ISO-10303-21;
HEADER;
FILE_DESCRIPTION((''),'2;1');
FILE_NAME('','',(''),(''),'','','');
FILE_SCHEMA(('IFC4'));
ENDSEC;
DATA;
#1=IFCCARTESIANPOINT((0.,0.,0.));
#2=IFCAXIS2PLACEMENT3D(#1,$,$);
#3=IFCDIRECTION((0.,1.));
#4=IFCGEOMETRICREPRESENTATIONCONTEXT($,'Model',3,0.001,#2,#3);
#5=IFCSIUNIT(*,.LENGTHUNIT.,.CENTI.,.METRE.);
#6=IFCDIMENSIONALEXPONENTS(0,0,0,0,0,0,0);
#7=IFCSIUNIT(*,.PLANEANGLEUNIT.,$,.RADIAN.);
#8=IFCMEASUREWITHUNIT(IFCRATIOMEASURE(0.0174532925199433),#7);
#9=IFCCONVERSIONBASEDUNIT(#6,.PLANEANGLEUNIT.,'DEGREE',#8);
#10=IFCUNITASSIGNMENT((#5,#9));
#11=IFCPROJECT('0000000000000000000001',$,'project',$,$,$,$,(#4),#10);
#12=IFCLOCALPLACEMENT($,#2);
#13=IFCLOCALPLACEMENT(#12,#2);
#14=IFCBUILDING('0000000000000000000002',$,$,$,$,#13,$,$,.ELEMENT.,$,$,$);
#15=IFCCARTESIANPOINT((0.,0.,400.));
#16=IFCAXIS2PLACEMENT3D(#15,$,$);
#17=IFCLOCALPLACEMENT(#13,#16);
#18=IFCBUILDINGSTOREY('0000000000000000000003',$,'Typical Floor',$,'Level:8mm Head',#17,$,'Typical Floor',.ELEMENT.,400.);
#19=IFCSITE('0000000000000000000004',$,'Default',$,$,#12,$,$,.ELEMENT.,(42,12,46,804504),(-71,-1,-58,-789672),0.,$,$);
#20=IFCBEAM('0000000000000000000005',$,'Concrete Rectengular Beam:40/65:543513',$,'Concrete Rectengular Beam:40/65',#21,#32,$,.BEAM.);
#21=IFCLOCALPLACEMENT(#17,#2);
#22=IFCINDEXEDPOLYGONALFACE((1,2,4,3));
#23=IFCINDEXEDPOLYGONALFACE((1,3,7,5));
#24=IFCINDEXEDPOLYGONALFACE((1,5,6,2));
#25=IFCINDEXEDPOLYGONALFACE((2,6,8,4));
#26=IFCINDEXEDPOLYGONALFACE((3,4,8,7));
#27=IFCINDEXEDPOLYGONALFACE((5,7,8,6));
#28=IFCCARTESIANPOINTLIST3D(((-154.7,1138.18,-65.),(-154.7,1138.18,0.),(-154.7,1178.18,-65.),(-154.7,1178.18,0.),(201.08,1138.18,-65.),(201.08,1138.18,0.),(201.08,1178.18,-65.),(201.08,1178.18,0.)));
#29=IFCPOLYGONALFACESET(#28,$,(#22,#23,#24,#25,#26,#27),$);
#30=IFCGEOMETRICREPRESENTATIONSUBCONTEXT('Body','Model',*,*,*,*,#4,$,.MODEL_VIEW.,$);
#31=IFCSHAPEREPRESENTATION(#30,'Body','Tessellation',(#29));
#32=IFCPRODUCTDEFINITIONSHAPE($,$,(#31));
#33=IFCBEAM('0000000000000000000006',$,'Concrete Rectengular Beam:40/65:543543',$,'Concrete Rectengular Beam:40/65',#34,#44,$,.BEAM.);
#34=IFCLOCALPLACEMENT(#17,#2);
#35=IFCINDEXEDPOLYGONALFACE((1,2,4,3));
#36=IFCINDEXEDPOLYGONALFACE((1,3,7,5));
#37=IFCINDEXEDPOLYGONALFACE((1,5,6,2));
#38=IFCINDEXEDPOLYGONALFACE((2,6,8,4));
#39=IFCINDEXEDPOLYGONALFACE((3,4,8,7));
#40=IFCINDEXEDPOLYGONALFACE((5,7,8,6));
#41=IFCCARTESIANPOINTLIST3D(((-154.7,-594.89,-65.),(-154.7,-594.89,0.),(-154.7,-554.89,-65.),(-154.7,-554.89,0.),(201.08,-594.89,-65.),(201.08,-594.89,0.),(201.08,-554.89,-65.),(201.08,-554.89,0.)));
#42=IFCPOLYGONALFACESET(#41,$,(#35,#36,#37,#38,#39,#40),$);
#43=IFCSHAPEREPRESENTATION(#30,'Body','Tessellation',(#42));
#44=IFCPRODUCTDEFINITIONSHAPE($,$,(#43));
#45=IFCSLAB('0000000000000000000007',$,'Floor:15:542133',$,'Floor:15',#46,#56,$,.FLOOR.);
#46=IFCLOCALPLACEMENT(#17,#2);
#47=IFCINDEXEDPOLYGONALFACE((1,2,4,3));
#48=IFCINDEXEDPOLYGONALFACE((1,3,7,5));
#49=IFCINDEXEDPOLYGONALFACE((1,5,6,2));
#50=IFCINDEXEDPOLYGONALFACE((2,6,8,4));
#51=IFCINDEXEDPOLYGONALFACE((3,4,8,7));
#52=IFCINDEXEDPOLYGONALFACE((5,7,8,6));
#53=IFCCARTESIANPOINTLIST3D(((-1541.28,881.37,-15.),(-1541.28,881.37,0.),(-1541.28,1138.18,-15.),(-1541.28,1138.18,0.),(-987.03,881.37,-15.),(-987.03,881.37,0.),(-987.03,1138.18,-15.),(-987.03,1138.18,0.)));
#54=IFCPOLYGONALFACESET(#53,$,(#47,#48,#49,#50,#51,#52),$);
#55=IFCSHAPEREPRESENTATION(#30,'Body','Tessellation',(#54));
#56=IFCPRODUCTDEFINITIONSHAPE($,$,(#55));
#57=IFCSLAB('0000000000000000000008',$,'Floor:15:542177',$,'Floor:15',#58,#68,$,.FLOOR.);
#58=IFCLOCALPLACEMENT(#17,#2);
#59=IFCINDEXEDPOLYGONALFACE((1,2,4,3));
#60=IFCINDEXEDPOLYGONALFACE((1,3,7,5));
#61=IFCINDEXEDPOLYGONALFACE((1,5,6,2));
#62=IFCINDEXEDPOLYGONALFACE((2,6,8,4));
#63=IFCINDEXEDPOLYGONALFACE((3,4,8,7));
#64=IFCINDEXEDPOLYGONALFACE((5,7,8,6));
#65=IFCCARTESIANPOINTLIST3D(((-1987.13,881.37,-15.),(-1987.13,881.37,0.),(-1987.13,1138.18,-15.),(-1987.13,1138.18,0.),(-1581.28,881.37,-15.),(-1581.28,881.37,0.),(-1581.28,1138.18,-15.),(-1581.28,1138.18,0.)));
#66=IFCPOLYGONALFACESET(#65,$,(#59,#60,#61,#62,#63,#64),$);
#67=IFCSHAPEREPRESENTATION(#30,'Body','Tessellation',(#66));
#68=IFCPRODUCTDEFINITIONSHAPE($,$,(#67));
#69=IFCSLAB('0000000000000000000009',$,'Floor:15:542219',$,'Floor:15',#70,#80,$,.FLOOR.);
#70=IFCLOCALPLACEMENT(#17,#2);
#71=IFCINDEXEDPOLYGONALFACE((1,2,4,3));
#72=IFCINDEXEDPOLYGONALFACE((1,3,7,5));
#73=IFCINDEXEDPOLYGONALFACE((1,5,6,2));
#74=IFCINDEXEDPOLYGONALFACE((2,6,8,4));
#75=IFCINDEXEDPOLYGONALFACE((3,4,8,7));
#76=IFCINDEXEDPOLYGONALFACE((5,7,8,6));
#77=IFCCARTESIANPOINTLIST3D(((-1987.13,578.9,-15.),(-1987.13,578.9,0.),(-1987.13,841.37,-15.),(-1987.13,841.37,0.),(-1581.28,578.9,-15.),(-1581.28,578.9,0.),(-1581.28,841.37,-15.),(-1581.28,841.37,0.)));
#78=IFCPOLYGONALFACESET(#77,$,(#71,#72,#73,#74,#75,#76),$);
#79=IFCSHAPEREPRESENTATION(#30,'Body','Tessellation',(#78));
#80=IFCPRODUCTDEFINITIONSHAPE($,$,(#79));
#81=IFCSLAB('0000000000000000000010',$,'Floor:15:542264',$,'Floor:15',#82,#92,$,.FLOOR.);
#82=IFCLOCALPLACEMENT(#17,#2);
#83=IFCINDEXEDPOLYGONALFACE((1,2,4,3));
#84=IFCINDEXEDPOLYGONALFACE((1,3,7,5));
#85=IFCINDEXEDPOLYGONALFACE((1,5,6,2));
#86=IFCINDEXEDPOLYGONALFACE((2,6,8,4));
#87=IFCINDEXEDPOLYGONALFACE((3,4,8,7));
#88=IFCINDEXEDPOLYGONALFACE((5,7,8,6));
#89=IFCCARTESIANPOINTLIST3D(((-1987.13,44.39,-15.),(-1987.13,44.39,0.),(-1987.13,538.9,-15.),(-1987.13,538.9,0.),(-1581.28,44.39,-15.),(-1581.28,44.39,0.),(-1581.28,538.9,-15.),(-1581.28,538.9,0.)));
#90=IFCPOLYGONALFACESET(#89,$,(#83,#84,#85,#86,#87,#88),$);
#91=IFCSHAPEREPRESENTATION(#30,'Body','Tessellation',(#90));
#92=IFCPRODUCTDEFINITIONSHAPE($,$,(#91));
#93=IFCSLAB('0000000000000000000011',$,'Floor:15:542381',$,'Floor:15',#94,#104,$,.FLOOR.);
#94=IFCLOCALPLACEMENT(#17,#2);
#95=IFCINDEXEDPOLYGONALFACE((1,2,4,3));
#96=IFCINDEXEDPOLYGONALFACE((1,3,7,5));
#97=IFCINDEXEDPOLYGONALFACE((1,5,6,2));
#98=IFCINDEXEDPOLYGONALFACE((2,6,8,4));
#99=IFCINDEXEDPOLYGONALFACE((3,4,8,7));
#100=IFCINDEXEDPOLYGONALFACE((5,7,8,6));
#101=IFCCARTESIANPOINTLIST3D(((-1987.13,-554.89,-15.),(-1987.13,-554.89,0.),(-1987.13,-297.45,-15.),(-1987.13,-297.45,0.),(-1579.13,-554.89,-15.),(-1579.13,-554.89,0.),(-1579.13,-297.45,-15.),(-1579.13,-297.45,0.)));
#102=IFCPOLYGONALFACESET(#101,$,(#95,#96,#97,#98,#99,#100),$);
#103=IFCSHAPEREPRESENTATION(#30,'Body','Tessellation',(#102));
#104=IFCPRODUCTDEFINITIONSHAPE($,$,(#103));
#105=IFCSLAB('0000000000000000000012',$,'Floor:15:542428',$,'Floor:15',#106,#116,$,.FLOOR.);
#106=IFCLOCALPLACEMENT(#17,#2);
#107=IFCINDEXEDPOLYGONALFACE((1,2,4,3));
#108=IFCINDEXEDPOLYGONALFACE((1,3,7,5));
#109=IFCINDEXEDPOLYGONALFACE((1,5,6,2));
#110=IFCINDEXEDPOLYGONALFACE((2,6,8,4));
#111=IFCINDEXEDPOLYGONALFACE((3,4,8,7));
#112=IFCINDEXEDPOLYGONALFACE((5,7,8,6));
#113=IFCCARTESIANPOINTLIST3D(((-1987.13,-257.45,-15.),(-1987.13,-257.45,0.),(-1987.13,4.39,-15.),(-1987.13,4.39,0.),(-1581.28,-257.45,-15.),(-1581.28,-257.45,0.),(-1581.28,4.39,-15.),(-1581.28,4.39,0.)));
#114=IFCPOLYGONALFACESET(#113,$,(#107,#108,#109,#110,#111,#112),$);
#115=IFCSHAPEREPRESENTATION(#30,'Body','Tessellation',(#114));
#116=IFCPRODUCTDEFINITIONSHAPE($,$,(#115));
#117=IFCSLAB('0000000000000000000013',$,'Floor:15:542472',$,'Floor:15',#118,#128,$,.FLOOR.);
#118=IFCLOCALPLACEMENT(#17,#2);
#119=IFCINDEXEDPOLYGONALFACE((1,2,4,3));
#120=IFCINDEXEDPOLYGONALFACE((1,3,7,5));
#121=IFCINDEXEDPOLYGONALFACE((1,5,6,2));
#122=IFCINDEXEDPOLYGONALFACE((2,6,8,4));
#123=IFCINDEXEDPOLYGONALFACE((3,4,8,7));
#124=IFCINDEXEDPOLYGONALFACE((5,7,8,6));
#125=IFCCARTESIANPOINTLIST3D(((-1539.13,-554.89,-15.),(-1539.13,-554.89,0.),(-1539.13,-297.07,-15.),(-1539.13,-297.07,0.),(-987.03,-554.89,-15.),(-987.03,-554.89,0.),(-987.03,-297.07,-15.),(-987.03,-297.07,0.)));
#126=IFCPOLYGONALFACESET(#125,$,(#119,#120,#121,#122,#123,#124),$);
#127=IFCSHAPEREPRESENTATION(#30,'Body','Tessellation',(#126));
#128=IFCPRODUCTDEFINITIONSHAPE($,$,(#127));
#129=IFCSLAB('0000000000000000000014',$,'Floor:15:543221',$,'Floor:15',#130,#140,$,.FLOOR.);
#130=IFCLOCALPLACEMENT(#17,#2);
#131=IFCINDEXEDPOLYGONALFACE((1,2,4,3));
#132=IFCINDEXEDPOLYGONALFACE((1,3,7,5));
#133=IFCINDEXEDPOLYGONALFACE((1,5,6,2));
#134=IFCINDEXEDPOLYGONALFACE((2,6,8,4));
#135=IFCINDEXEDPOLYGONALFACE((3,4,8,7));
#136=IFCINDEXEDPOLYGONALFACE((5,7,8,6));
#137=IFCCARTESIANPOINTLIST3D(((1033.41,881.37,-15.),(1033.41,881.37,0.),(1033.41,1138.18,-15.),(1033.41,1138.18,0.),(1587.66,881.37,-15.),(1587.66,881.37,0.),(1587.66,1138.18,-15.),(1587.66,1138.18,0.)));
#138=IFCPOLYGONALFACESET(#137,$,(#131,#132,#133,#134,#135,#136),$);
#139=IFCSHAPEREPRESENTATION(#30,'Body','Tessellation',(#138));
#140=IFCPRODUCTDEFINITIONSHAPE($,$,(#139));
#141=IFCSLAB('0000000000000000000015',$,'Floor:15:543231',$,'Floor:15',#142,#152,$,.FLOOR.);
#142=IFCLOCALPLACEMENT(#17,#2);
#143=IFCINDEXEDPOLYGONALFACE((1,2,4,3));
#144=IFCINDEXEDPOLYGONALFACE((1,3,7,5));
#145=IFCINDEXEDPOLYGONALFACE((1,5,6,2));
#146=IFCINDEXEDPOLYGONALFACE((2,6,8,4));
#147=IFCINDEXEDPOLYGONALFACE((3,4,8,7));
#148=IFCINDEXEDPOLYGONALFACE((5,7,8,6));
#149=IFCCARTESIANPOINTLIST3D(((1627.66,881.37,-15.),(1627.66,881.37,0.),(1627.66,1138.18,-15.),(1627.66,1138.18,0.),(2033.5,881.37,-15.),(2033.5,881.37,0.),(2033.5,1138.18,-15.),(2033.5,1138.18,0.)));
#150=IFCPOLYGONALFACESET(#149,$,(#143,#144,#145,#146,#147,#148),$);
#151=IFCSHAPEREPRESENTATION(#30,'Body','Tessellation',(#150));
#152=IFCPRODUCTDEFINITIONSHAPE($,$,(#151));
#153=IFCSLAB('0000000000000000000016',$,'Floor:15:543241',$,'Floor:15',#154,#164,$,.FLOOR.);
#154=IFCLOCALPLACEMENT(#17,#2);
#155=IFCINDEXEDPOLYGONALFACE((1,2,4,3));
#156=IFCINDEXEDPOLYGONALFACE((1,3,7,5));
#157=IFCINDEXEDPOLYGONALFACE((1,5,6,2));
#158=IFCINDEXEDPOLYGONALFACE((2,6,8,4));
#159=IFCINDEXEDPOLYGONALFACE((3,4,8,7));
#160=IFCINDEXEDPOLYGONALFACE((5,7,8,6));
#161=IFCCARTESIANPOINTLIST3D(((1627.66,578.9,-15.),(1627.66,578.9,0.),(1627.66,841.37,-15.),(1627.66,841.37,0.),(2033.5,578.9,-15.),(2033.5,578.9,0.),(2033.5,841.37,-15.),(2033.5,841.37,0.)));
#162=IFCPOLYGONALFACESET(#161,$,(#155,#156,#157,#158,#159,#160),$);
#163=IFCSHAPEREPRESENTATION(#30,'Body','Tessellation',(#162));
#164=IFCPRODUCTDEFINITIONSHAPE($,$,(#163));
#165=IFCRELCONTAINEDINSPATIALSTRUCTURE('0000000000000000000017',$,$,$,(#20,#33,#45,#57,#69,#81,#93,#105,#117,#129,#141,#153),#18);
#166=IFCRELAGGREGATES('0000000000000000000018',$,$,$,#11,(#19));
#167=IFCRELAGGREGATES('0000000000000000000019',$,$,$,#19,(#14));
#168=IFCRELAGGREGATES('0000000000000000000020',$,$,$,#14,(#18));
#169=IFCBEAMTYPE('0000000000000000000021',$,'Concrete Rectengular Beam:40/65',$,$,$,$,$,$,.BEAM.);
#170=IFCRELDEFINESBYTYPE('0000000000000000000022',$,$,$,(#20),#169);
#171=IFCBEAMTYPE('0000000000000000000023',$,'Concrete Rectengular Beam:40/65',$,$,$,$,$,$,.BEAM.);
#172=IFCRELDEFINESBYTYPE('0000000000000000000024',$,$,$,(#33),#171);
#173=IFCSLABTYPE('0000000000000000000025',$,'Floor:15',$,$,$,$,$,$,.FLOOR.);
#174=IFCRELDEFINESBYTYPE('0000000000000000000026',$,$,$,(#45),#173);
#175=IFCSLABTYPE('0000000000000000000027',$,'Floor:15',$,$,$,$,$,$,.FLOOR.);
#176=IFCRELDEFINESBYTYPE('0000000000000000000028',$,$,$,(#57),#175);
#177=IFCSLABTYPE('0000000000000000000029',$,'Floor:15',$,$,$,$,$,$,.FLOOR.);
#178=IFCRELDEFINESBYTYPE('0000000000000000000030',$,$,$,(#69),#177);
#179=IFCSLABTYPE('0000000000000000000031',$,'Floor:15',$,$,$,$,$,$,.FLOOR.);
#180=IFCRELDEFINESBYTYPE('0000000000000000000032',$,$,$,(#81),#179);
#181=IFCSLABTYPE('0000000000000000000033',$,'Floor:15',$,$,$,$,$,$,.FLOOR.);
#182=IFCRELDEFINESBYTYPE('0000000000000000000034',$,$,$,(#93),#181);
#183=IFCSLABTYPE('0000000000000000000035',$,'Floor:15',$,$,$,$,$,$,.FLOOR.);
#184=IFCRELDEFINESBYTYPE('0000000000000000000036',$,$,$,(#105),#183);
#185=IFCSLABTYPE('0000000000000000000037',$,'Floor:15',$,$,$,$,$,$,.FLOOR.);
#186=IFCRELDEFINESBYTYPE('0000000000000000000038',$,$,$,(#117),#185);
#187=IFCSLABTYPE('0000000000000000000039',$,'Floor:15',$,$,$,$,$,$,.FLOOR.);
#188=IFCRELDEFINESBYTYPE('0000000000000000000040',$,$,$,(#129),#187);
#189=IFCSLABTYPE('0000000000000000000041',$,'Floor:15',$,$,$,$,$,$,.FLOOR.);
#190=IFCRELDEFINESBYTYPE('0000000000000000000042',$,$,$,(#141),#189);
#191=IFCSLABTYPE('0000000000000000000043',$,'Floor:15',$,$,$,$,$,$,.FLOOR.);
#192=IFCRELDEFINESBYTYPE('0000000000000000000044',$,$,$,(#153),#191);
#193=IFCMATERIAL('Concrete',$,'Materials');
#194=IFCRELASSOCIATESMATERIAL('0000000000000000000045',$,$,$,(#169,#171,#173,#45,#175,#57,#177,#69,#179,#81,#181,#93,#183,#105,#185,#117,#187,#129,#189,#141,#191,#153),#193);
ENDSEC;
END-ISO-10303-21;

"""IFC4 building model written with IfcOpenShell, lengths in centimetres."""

from ifc_helpers import new_model, entity, si_unit, converted_unit, direction, frame, origin, place, context, subcontext, project, spatial, indexed_curve, outline, extrude, source, transform, mapped, material, type_object, type_shapes, element, save


model = new_model("IFC4")

# Units and contexts
model_context = context("Model", 3, precision=0.001, world=origin(), true_north=direction((0.0, 1.0)))
body_context = subcontext(model_context, "Body", "Model", "MODEL_VIEW")
ifc_project = project(units=[si_unit("LENGTHUNIT", "METRE", prefix="CENTI"), converted_unit("PLANEANGLEUNIT", "DEGREE", entity("IfcRatioMeasure", 0.0174532925199433), si_unit("PLANEANGLEUNIT", "RADIAN"), dimensions=[0, 0, 0, 0, 0, 0, 0])], contexts=[model_context])

# Site, building, storey
site_placement = place(None, origin())
site = spatial("IfcSite", under=ifc_project, at=site_placement, Name="Default", CompositionType="ELEMENT", RefLatitude=(42, 12, 46, 804504), RefLongitude=(-71, -1, -58, -789672), RefElevation=0.0)
building_placement = place(site_placement, origin())
building = spatial("IfcBuilding", under=site, at=building_placement, CompositionType="ELEMENT")
storey_placement = place(building_placement, frame((0.0, 0.0, 400.0)))
storey = spatial("IfcBuildingStorey", under=building, at=storey_placement, Name="Typical Floor", ObjectType="Level:8mm Head", LongName="Typical Floor", CompositionType="ELEMENT", Elevation=400.0)

# Beams
ifc_material = material(Name="Concrete", Category="Materials")
beam_type_1 = type_object("IfcBeamType", Name="Concrete Rectengular Beam:40/65", PredefinedType="BEAM", material=ifc_material)
shared_shape_1 = source(origin(), body_context, "Body", "SweptSolid", [
    extrude(outline(indexed_curve([(-32.5, -20.0), (32.5, -20.0), (32.5, 20.0), (-32.5, 20.0), (-32.5, -20.0)], self_intersect=False)), frame((-154.7, 1158.18, 367.5), z_axis=(1.0, 0.0, 0.0), x_axis=(0.0, 0.0, -1.0)), (0.0, 0.0, 1.0), 355.78),
])
type_shapes(beam_type_1, [shared_shape_1])
beam_1_placement = place(storey_placement, frame((0.0, 0.0, -400.0)))
element("IfcBeam", 1, at=beam_1_placement, inside=storey, type_object=beam_type_1, Name="Concrete Rectengular Beam:40/65:543513", ObjectType="Concrete Rectengular Beam:40/65", PredefinedType="BEAM", context=body_context, shape_type="MappedRepresentation", body=[
    mapped(shared_shape_1, transform((0.0, 0.0, 0.0), scale=1.0)),
])
beam_type_2 = type_object("IfcBeamType", Name="Concrete Rectengular Beam:40/65", PredefinedType="BEAM", material=ifc_material)
shared_shape_2 = source(origin(), body_context, "Body", "SweptSolid", [
    extrude(outline(indexed_curve([(-32.5, -20.0), (32.5, -20.0), (32.5, 20.0), (-32.5, 20.0), (-32.5, -20.0)], self_intersect=False)), frame((-154.7, -574.89, 367.5), z_axis=(1.0, 0.0, 0.0), x_axis=(0.0, 0.0, -1.0)), (0.0, 0.0, 1.0), 355.78),
])
type_shapes(beam_type_2, [shared_shape_2])
beam_2_placement = place(storey_placement, frame((0.0, 0.0, -400.0)))
element("IfcBeam", 2, at=beam_2_placement, inside=storey, type_object=beam_type_2, Name="Concrete Rectengular Beam:40/65:543543", ObjectType="Concrete Rectengular Beam:40/65", PredefinedType="BEAM", context=body_context, shape_type="MappedRepresentation", body=[
    mapped(shared_shape_2, transform((0.0, 0.0, 0.0), scale=1.0)),
])

# Slabs
slab_type_1 = type_object("IfcSlabType", Name="Floor:15", PredefinedType="FLOOR", material=ifc_material)
slab_1_placement = place(storey_placement, origin())
element("IfcSlab", 3, at=slab_1_placement, inside=storey, type_object=slab_type_1, material=ifc_material, Name="Floor:15:542133", ObjectType="Floor:15", PredefinedType="FLOOR", context=body_context, shape_type="SweptSolid", body=[
    extrude(outline(indexed_curve([(-128.4, -277.12), (128.4, -277.12), (128.4, 277.12), (-128.4, 277.12), (-128.4, -277.12)], self_intersect=False)), frame((-1264.16, 1009.77, 0.0), z_axis=(0.0, 0.0, -1.0), x_axis=(0.0, 1.0, 0.0)), (0.0, 0.0, 1.0), 15.0),
])
slab_type_2 = type_object("IfcSlabType", Name="Floor:15", PredefinedType="FLOOR", material=ifc_material)
slab_2_placement = place(storey_placement, origin())
element("IfcSlab", 4, at=slab_2_placement, inside=storey, type_object=slab_type_2, material=ifc_material, Name="Floor:15:542177", ObjectType="Floor:15", PredefinedType="FLOOR", context=body_context, shape_type="SweptSolid", body=[
    extrude(outline(indexed_curve([(-128.4, -202.92), (128.4, -202.92), (128.4, 202.92), (-128.4, 202.92), (-128.4, -202.92)], self_intersect=False)), frame((-1784.2, 1009.77, 0.0), z_axis=(0.0, 0.0, -1.0), x_axis=(0.0, 1.0, 0.0)), (0.0, 0.0, 1.0), 15.0),
])
slab_type_3 = type_object("IfcSlabType", Name="Floor:15", PredefinedType="FLOOR", material=ifc_material)
slab_3_placement = place(storey_placement, origin())
element("IfcSlab", 5, at=slab_3_placement, inside=storey, type_object=slab_type_3, material=ifc_material, Name="Floor:15:542219", ObjectType="Floor:15", PredefinedType="FLOOR", context=body_context, shape_type="SweptSolid", body=[
    extrude(outline(indexed_curve([(-131.23, -202.92), (131.23, -202.92), (131.23, 202.92), (-131.23, 202.92), (-131.23, -202.92)], self_intersect=False)), frame((-1784.2, 710.13, 0.0), z_axis=(0.0, 0.0, -1.0), x_axis=(0.0, 1.0, 0.0)), (0.0, 0.0, 1.0), 15.0),
])
slab_type_4 = type_object("IfcSlabType", Name="Floor:15", PredefinedType="FLOOR", material=ifc_material)
slab_4_placement = place(storey_placement, origin())
element("IfcSlab", 6, at=slab_4_placement, inside=storey, type_object=slab_type_4, material=ifc_material, Name="Floor:15:542264", ObjectType="Floor:15", PredefinedType="FLOOR", context=body_context, shape_type="SweptSolid", body=[
    extrude(outline(indexed_curve([(-247.25, -202.92), (247.25, -202.92), (247.25, 202.92), (-247.25, 202.92), (-247.25, -202.92)], self_intersect=False)), frame((-1784.2, 291.65, 0.0), z_axis=(0.0, 0.0, -1.0), x_axis=(0.0, 1.0, 0.0)), (0.0, 0.0, 1.0), 15.0),
])
slab_type_5 = type_object("IfcSlabType", Name="Floor:15", PredefinedType="FLOOR", material=ifc_material)
slab_5_placement = place(storey_placement, origin())
element("IfcSlab", 7, at=slab_5_placement, inside=storey, type_object=slab_type_5, material=ifc_material, Name="Floor:15:542381", ObjectType="Floor:15", PredefinedType="FLOOR", context=body_context, shape_type="SweptSolid", body=[
    extrude(outline(indexed_curve([(-128.72, -204.0), (128.72, -204.0), (128.72, 204.0), (-128.72, 204.0), (-128.72, -204.0)], self_intersect=False)), frame((-1783.13, -426.17, 0.0), z_axis=(0.0, 0.0, -1.0), x_axis=(0.0, 1.0, 0.0)), (0.0, 0.0, 1.0), 15.0),
])
slab_type_6 = type_object("IfcSlabType", Name="Floor:15", PredefinedType="FLOOR", material=ifc_material)
slab_6_placement = place(storey_placement, origin())
element("IfcSlab", 8, at=slab_6_placement, inside=storey, type_object=slab_type_6, material=ifc_material, Name="Floor:15:542428", ObjectType="Floor:15", PredefinedType="FLOOR", context=body_context, shape_type="SweptSolid", body=[
    extrude(outline(indexed_curve([(-130.92, -202.92), (130.92, -202.92), (130.92, 202.92), (-130.92, 202.92), (-130.92, -202.92)], self_intersect=False)), frame((-1784.2, -126.53, 0.0), z_axis=(0.0, 0.0, -1.0), x_axis=(0.0, 1.0, 0.0)), (0.0, 0.0, 1.0), 15.0),
])
slab_type_7 = type_object("IfcSlabType", Name="Floor:15", PredefinedType="FLOOR", material=ifc_material)
slab_7_placement = place(storey_placement, origin())
element("IfcSlab", 9, at=slab_7_placement, inside=storey, type_object=slab_type_7, material=ifc_material, Name="Floor:15:542472", ObjectType="Floor:15", PredefinedType="FLOOR", context=body_context, shape_type="SweptSolid", body=[
    extrude(outline(indexed_curve([(-128.91, -276.05), (128.91, -276.05), (128.91, 276.05), (-128.91, 276.05), (-128.91, -276.05)], self_intersect=False)), frame((-1263.08, -425.98, 0.0), z_axis=(0.0, 0.0, -1.0), x_axis=(0.0, 1.0, 0.0)), (0.0, 0.0, 1.0), 15.0),
])
slab_type_8 = type_object("IfcSlabType", Name="Floor:15", PredefinedType="FLOOR", material=ifc_material)
slab_8_placement = place(storey_placement, origin())
element("IfcSlab", 10, at=slab_8_placement, inside=storey, type_object=slab_type_8, material=ifc_material, Name="Floor:15:543221", ObjectType="Floor:15", PredefinedType="FLOOR", context=body_context, shape_type="SweptSolid", body=[
    extrude(outline(indexed_curve([(-128.4, -277.12), (128.4, -277.12), (128.4, 277.12), (-128.4, 277.12), (-128.4, -277.12)], self_intersect=False)), frame((1310.54, 1009.77, 0.0), z_axis=(0.0, 0.0, -1.0), x_axis=(0.0, 1.0, 0.0)), (0.0, 0.0, 1.0), 15.0),
])
slab_type_9 = type_object("IfcSlabType", Name="Floor:15", PredefinedType="FLOOR", material=ifc_material)
slab_9_placement = place(storey_placement, origin())
element("IfcSlab", 11, at=slab_9_placement, inside=storey, type_object=slab_type_9, material=ifc_material, Name="Floor:15:543231", ObjectType="Floor:15", PredefinedType="FLOOR", context=body_context, shape_type="SweptSolid", body=[
    extrude(outline(indexed_curve([(-128.4, -202.92), (128.4, -202.92), (128.4, 202.92), (-128.4, 202.92), (-128.4, -202.92)], self_intersect=False)), frame((1830.58, 1009.77, 0.0), z_axis=(0.0, 0.0, -1.0), x_axis=(0.0, 1.0, 0.0)), (0.0, 0.0, 1.0), 15.0),
])
slab_type_10 = type_object("IfcSlabType", Name="Floor:15", PredefinedType="FLOOR", material=ifc_material)
slab_10_placement = place(storey_placement, origin())
element("IfcSlab", 12, at=slab_10_placement, inside=storey, type_object=slab_type_10, material=ifc_material, Name="Floor:15:543241", ObjectType="Floor:15", PredefinedType="FLOOR", context=body_context, shape_type="SweptSolid", body=[
    extrude(outline(indexed_curve([(-131.23, -202.92), (131.23, -202.92), (131.23, 202.92), (-131.23, 202.92), (-131.23, -202.92)], self_intersect=False)), frame((1830.58, 710.13, 0.0), z_axis=(0.0, 0.0, -1.0), x_axis=(0.0, 1.0, 0.0)), (0.0, 0.0, 1.0), 15.0),
])

save(model, "model.ifc")
